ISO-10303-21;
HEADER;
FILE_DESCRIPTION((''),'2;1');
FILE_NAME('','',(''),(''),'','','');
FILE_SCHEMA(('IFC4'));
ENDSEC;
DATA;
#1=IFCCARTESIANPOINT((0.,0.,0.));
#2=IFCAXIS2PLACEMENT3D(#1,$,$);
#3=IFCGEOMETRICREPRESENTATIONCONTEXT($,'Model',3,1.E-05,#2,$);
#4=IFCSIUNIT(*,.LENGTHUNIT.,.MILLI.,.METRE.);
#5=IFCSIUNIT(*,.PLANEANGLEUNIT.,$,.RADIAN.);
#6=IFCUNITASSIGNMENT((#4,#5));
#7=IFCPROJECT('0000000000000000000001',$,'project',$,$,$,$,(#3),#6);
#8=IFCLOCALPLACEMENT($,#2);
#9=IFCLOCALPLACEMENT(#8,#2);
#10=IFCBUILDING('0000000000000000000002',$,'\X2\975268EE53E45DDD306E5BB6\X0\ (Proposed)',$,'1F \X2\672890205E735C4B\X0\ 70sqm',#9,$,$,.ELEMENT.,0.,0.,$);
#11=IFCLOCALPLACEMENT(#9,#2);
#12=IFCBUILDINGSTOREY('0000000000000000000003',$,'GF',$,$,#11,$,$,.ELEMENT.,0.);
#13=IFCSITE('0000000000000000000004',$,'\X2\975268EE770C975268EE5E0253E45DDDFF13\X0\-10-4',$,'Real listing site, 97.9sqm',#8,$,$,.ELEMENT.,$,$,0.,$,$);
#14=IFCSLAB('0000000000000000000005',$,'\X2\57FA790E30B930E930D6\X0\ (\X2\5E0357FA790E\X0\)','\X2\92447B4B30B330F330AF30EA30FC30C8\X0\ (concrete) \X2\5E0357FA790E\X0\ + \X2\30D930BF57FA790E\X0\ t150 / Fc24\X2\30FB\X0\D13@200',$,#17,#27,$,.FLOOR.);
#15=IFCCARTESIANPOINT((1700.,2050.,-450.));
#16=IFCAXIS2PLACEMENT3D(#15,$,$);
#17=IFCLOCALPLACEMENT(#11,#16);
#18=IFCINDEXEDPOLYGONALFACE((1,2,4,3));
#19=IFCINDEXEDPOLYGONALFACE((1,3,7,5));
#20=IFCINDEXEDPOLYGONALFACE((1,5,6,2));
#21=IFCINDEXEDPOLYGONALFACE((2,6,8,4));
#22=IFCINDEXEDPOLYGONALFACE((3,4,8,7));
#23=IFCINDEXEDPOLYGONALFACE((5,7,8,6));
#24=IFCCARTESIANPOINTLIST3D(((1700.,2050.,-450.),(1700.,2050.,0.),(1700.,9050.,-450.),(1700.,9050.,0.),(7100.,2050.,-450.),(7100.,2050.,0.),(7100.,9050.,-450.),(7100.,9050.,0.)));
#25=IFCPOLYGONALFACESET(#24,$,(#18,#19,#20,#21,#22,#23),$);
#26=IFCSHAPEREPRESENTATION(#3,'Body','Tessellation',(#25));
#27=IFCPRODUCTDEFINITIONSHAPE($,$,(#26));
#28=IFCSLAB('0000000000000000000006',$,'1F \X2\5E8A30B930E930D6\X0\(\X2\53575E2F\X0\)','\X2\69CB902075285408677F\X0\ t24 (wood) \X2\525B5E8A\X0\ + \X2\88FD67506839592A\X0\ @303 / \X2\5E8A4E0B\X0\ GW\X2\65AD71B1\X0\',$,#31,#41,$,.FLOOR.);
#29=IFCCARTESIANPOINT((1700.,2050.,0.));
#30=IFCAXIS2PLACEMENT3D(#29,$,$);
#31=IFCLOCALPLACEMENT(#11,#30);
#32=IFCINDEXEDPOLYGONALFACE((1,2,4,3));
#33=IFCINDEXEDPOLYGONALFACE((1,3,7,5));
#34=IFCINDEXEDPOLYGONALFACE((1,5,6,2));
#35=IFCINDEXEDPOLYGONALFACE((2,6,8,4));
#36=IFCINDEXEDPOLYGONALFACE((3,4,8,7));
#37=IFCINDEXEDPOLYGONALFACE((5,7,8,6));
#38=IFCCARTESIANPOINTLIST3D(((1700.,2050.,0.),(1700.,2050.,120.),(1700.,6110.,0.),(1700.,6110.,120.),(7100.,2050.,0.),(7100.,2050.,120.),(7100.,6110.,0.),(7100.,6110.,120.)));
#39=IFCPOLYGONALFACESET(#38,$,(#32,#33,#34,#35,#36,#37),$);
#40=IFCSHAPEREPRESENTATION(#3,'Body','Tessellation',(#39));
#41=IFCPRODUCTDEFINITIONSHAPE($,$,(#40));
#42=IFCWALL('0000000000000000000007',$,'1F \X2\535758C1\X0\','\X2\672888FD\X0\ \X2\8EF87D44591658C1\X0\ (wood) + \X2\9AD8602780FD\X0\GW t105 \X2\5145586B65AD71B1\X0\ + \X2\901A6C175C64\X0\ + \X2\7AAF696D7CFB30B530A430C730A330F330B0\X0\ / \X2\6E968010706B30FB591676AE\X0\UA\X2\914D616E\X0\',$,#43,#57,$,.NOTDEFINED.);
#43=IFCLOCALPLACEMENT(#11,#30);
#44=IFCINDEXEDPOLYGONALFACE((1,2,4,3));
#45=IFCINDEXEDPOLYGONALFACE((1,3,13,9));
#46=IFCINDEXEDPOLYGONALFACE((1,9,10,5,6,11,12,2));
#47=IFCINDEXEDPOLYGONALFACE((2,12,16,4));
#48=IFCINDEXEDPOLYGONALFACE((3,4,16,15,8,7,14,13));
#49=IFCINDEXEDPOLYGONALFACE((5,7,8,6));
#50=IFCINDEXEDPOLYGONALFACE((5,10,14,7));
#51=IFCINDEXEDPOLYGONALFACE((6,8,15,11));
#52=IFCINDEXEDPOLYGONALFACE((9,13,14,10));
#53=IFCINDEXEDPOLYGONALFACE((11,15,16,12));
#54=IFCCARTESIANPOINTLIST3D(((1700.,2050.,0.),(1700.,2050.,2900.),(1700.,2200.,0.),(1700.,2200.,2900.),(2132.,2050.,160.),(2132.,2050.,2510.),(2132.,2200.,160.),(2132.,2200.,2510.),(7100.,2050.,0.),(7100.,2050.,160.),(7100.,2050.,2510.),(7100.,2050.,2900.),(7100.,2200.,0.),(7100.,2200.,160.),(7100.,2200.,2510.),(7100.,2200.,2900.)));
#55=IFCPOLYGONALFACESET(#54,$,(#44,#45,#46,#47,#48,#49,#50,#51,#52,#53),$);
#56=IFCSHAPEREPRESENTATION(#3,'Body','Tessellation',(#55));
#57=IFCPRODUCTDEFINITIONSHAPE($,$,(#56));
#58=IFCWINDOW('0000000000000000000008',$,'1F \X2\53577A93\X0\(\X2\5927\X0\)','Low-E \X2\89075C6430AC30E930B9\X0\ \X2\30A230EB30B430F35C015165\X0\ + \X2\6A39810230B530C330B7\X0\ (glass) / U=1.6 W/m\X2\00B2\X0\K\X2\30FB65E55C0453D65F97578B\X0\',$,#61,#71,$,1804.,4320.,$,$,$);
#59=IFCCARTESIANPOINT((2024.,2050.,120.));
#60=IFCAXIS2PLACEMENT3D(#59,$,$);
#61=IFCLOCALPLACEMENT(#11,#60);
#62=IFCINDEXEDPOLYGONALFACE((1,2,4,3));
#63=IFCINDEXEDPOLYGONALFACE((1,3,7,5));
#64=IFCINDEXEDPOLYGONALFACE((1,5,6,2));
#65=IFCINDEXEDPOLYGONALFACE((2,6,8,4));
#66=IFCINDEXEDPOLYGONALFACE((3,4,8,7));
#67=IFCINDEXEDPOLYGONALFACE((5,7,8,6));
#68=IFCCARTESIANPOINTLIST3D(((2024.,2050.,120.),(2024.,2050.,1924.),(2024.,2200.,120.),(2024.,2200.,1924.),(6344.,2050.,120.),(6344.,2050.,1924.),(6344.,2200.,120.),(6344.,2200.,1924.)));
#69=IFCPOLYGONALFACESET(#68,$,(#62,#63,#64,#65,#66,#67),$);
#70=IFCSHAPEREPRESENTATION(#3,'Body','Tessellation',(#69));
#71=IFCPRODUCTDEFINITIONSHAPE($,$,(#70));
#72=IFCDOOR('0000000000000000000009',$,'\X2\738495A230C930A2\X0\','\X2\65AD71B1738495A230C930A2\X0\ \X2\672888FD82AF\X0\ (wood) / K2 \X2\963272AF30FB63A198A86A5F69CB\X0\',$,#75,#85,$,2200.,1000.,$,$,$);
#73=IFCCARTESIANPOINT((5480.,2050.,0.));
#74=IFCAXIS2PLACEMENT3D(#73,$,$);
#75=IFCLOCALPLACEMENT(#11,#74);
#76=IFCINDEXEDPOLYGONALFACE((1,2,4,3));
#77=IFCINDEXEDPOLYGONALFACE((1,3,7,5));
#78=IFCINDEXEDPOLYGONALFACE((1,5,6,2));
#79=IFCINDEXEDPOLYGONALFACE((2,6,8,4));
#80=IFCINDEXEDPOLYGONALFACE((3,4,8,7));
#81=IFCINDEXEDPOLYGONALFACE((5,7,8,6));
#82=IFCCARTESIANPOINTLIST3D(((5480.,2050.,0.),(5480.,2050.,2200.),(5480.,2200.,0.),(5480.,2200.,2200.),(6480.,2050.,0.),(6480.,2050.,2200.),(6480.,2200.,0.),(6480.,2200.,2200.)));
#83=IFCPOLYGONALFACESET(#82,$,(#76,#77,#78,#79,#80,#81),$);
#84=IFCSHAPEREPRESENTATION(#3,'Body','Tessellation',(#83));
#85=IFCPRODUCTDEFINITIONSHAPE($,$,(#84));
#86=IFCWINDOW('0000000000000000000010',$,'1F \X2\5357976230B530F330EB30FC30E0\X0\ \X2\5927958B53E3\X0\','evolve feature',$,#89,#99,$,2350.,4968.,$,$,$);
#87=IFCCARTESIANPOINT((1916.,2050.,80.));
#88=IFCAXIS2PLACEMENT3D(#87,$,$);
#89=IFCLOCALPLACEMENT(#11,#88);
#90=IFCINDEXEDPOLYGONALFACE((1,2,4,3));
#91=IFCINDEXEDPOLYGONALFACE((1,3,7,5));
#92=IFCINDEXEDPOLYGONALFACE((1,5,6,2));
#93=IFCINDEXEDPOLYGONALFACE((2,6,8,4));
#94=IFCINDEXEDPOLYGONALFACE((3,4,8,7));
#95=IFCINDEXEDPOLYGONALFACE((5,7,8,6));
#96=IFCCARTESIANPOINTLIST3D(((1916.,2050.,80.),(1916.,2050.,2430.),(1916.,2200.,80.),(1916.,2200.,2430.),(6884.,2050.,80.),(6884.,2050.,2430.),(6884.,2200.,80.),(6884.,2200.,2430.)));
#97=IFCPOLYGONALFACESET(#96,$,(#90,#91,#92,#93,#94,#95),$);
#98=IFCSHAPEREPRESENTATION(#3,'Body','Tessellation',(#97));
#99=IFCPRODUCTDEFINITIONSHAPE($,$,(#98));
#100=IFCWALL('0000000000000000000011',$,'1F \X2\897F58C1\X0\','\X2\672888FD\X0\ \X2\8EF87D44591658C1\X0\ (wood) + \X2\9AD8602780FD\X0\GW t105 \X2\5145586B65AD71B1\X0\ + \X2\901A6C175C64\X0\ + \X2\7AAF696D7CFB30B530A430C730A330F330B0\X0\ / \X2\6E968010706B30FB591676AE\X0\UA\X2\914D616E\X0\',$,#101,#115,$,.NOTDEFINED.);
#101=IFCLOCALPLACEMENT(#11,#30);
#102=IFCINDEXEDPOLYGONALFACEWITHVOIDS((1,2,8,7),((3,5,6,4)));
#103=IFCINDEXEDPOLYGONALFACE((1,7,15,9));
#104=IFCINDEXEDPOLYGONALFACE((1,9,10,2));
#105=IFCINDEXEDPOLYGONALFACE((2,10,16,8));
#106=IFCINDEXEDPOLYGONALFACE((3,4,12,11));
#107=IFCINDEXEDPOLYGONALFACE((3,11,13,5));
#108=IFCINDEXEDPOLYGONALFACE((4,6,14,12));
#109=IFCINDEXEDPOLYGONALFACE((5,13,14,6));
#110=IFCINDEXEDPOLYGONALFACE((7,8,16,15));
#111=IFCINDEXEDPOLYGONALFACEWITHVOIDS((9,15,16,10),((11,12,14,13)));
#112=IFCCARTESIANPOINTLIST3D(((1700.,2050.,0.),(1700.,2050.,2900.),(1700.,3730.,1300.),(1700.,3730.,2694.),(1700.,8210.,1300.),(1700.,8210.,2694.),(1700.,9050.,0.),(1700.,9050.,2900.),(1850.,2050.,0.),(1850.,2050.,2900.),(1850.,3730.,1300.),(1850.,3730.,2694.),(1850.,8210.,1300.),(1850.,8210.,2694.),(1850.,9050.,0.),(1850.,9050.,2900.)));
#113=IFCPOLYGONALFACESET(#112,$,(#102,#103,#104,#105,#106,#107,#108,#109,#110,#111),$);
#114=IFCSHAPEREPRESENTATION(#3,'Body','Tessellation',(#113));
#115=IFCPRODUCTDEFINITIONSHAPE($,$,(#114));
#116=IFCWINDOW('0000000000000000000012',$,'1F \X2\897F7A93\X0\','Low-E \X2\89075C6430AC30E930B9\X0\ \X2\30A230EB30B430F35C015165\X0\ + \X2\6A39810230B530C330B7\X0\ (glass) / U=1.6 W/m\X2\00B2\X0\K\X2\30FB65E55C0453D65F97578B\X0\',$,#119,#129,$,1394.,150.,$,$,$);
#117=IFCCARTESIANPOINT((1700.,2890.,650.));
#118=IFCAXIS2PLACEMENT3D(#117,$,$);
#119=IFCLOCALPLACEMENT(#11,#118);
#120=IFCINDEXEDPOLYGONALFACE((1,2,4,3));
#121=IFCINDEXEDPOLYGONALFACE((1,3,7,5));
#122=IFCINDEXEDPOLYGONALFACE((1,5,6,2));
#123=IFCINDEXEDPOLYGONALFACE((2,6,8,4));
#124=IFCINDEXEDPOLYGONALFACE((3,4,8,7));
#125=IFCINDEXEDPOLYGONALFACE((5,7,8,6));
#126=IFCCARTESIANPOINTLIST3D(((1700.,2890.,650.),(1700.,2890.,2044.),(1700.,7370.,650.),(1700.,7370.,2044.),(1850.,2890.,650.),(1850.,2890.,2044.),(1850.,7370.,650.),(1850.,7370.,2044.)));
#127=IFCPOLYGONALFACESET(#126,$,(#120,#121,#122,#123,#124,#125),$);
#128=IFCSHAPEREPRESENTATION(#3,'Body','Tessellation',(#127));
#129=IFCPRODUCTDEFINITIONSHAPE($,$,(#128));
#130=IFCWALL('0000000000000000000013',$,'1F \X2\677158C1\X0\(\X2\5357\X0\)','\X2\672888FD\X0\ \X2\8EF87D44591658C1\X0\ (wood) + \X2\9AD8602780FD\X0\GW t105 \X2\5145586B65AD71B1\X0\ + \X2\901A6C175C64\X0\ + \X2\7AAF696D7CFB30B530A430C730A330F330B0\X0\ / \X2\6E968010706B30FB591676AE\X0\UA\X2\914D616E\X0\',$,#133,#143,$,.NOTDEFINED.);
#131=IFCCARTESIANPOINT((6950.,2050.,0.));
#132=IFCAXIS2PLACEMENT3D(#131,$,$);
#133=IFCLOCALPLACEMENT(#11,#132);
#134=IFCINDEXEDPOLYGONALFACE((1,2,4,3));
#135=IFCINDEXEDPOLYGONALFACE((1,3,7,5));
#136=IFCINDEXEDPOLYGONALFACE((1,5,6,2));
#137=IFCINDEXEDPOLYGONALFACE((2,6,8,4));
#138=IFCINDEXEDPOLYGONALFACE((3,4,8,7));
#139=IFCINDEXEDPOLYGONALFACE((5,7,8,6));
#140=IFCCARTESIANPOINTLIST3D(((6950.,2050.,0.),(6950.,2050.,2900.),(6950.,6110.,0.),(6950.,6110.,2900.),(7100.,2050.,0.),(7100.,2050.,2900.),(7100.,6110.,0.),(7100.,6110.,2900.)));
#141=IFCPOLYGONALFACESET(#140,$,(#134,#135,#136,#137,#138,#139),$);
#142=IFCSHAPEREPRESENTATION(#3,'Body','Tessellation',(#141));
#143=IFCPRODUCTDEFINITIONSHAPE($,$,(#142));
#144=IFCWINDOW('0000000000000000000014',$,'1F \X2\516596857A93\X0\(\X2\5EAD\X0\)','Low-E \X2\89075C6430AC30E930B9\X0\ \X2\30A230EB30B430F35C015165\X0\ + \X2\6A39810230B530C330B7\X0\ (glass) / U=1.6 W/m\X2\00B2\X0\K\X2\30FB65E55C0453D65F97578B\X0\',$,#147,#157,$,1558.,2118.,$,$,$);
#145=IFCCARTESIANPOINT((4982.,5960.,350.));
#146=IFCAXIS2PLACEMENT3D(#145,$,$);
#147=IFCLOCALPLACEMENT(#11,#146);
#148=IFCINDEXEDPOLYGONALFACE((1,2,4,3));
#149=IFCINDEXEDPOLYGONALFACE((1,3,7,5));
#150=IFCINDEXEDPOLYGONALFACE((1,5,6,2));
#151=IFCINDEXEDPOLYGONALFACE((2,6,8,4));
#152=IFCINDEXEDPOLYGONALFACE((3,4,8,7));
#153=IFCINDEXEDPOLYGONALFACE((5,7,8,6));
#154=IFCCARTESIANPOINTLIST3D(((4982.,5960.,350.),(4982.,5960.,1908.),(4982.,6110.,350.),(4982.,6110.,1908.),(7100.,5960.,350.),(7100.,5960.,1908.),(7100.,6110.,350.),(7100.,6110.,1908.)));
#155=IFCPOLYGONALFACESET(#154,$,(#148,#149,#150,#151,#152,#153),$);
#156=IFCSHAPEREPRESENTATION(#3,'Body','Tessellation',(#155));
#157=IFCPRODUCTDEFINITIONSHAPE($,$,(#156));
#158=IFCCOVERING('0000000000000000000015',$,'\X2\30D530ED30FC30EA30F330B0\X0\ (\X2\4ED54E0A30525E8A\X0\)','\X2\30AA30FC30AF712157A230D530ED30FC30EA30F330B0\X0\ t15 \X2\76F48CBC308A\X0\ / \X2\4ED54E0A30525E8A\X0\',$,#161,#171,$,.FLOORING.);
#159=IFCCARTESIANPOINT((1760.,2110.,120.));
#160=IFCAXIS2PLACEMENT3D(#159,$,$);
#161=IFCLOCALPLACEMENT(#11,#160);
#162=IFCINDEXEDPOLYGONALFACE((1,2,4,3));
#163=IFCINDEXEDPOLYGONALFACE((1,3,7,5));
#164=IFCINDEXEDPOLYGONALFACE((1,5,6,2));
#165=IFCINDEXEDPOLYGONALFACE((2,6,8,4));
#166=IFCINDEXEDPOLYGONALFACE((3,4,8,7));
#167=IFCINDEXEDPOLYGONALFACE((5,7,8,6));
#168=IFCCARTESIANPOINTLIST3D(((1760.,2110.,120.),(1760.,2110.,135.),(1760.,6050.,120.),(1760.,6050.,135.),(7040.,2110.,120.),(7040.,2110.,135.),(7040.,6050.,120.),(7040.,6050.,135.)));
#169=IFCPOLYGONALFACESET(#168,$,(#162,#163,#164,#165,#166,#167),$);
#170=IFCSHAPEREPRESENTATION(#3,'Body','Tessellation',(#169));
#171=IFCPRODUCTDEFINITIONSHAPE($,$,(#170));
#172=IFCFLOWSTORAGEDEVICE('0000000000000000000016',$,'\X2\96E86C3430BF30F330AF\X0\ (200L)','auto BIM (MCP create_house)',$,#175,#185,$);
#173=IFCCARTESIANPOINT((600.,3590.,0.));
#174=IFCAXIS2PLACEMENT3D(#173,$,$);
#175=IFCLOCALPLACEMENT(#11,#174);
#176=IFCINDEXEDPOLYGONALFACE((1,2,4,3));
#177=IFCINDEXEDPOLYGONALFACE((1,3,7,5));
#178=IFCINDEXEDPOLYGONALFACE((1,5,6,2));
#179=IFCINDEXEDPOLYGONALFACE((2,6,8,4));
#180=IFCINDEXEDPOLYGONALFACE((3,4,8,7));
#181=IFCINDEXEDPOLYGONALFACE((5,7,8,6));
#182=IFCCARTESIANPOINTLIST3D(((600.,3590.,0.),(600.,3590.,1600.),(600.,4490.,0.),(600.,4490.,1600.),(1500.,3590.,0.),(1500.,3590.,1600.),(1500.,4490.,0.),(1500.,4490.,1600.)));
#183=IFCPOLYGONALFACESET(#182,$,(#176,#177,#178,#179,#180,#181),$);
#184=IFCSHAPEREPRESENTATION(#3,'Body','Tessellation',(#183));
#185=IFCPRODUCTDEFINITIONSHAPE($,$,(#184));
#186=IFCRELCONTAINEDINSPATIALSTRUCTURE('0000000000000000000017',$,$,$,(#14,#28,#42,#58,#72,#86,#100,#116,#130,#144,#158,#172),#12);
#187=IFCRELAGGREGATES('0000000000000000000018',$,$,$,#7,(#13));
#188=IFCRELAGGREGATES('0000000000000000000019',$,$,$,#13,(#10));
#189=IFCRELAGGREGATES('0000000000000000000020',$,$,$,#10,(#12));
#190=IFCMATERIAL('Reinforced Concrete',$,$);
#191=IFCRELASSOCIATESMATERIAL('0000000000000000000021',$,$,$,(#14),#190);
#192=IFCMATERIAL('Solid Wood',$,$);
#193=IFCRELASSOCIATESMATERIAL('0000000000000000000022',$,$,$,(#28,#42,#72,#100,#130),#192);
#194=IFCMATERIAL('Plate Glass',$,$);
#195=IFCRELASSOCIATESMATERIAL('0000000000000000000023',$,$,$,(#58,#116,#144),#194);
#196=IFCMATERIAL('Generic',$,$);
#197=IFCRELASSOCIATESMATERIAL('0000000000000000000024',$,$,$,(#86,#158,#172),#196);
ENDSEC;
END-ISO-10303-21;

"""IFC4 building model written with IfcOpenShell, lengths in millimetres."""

from ifc_helpers import new_model, si_unit, frame, frame_2d, origin, place, context, project, spatial, rectangle, extrude, material, element, fill, save


model = new_model("IFC4")

# Units and contexts
model_context = context("Model", 3, precision=1e-05, world=origin())
ifc_project = project(units=[si_unit("LENGTHUNIT", "METRE", prefix="MILLI"), si_unit("PLANEANGLEUNIT", "RADIAN")], contexts=[model_context])

# Site, building, storey
site_placement = place(None, origin())
site = spatial("IfcSite", under=ifc_project, at=site_placement, Name="青森県青森市古川３-10-4", ObjectType="Real listing site, 97.9sqm", CompositionType="ELEMENT", RefElevation=0.0)
building_placement = place(site_placement, origin())
building = spatial("IfcBuilding", under=site, at=building_placement, Name="青森古川の家 (Proposed)", ObjectType="1F 木造平屋 70sqm", CompositionType="ELEMENT", ElevationOfRefHeight=0.0, ElevationOfTerrain=0.0)
storey_placement = place(building_placement, origin())
storey = spatial("IfcBuildingStorey", under=building, at=storey_placement, Name="GF", CompositionType="ELEMENT", Elevation=0.0)

# Slabs
ifc_material_1 = material(Name="Reinforced Concrete")
slab_1_placement = place(storey_placement, frame((1700.0, 2050.0, -450.0)))
element("IfcSlab", 1, at=slab_1_placement, inside=storey, material=ifc_material_1, Name="基礎スラブ (布基礎)", Description="鉄筋コンクリート (concrete) 布基礎 + ベタ基礎 t150 / Fc24・D13@200", PredefinedType="FLOOR", context=model_context, shape_type="SweptSolid", body=[
    extrude(rectangle(XDim=5400.0, YDim=7000.0, at=frame_2d((2700.0, 3500.0))), frame((1700.0, 2050.0, -450.0)), (0.0, 0.0, 1.0), 450.0),
])
ifc_material_2 = material(Name="Solid Wood")
slab_2_placement = place(storey_placement, frame((1700.0, 2050.0, 0.0)))
element("IfcSlab", 2, at=slab_2_placement, inside=storey, material=ifc_material_2, Name="1F 床スラブ(南帯)", Description="構造用合板 t24 (wood) 剛床 + 製材根太 @303 / 床下 GW断熱", PredefinedType="FLOOR", context=model_context, shape_type="SweptSolid", body=[
    extrude(rectangle(XDim=5400.0, YDim=4060.0, at=frame_2d((2700.0, 2030.0))), frame((1700.0, 2050.0, 0.0)), (0.0, 0.0, 1.0), 120.0),
])

# Wall, openings, windows, door
wall_1_placement = place(storey_placement, frame((1700.0, 2050.0, 0.0)))
wall_1 = element("IfcWall", 3, at=wall_1_placement, inside=storey, material=ifc_material_2, Name="1F 南壁", Description="木製 軸組外壁 (wood) + 高性能GW t105 充填断熱 + 通気層 + 窯業系サイディング / 準耐火・外皮UA配慮", PredefinedType="NOTDEFINED", context=model_context, shape_type="SweptSolid", body=[
    extrude(rectangle(XDim=5400.0, YDim=150.0, at=frame_2d((2700.0, 75.0))), frame((1700.0, 2050.0, 0.0)), (0.0, 0.0, 1.0), 2900.0),
])
opening_1_placement = place(storey_placement, frame((2024.0, 2050.0, 120.0)))
opening_1 = element("IfcOpeningElement", 4, at=opening_1_placement, cuts=wall_1, PredefinedType="NOTDEFINED", context=model_context, shape_type="SweptSolid", body=[
    extrude(rectangle(XDim=4320.0, YDim=150.0, at=frame_2d((2160.0, 75.0))), frame((2024.0, 2050.0, 120.0)), (0.0, 0.0, 1.0), 1804.0),
])
opening_2_placement = place(storey_placement, frame((5480.0, 2050.0, 0.0)))
opening_2 = element("IfcOpeningElement", 5, at=opening_2_placement, cuts=wall_1, PredefinedType="NOTDEFINED", context=model_context, shape_type="SweptSolid", body=[
    extrude(rectangle(XDim=1000.0, YDim=150.0, at=frame_2d((500.0, 75.0))), frame((5480.0, 2050.0, 0.0)), (0.0, 0.0, 1.0), 2200.0),
])
opening_3_placement = place(storey_placement, frame((1916.0, 2050.0, 80.0)))
opening_3 = element("IfcOpeningElement", 6, at=opening_3_placement, cuts=wall_1, PredefinedType="NOTDEFINED", context=model_context, shape_type="SweptSolid", body=[
    extrude(rectangle(XDim=4968.0, YDim=150.0, at=frame_2d((2484.0, 75.0))), frame((1916.0, 2050.0, 80.0)), (0.0, 0.0, 1.0), 2350.0),
])
ifc_material_3 = material(Name="Plate Glass")
window_1_placement = place(storey_placement, frame((2024.0, 2050.0, 120.0)))
window_1 = element("IfcWindow", 7, at=window_1_placement, inside=storey, material=ifc_material_3, Name="1F 南窓(大)", Description="Low-E 複層ガラス アルゴン封入 + 樹脂サッシ (glass) / U=1.6 W/m²K・日射取得型", OverallHeight=1804.0, OverallWidth=4320.0, context=model_context, shape_type="SweptSolid", body=[
    extrude(rectangle(XDim=4320.0, YDim=150.0, at=frame_2d((2160.0, 75.0))), frame((2024.0, 2050.0, 120.0)), (0.0, 0.0, 1.0), 1804.0),
])
fill(opening_1, window_1)
door_1_placement = place(storey_placement, frame((5480.0, 2050.0, 0.0)))
door_1 = element("IfcDoor", 8, at=door_1_placement, inside=storey, material=ifc_material_2, Name="玄関ドア", Description="断熱玄関ドア 木製芯 (wood) / K2 防犯・採風機構", OverallHeight=2200.0, OverallWidth=1000.0, context=model_context, shape_type="SweptSolid", body=[
    extrude(rectangle(XDim=1000.0, YDim=150.0, at=frame_2d((500.0, 75.0))), frame((5480.0, 2050.0, 0.0)), (0.0, 0.0, 1.0), 2200.0),
])
fill(opening_2, door_1)
ifc_material_4 = material(Name="Generic")
window_2_placement = place(storey_placement, frame((1916.0, 2050.0, 80.0)))
window_2 = element("IfcWindow", 9, at=window_2_placement, inside=storey, material=ifc_material_4, Name="1F 南面サンルーム 大開口", Description="evolve feature", OverallHeight=2350.0, OverallWidth=4968.0, context=model_context, shape_type="SweptSolid", body=[
    extrude(rectangle(XDim=4968.0, YDim=150.0, at=frame_2d((2484.0, 75.0))), frame((1916.0, 2050.0, 80.0)), (0.0, 0.0, 1.0), 2350.0),
])
fill(opening_3, window_2)

# Walls, openings, windows
wall_2_placement = place(storey_placement, frame((1700.0, 2050.0, 0.0)))
wall_2 = element("IfcWall", 10, at=wall_2_placement, inside=storey, material=ifc_material_2, Name="1F 西壁", Description="木製 軸組外壁 (wood) + 高性能GW t105 充填断熱 + 通気層 + 窯業系サイディング / 準耐火・外皮UA配慮", PredefinedType="NOTDEFINED", context=model_context, shape_type="SweptSolid", body=[
    extrude(rectangle(XDim=150.0, YDim=7000.0, at=frame_2d((75.0, 3500.0))), frame((1700.0, 2050.0, 0.0)), (0.0, 0.0, 1.0), 2900.0),
])
opening_4_placement = place(storey_placement, frame((1700.0, 2890.0, 650.0)))
opening_4 = element("IfcOpeningElement", 11, at=opening_4_placement, cuts=wall_2, PredefinedType="NOTDEFINED", context=model_context, shape_type="SweptSolid", body=[
    extrude(rectangle(XDim=150.0, YDim=4480.0, at=frame_2d((75.0, 2240.0))), frame((1700.0, 2890.0, 650.0)), (0.0, 0.0, 1.0), 1394.0),
])
window_3_placement = place(storey_placement, frame((1700.0, 2890.0, 650.0)))
window_3 = element("IfcWindow", 12, at=window_3_placement, inside=storey, material=ifc_material_3, Name="1F 西窓", Description="Low-E 複層ガラス アルゴン封入 + 樹脂サッシ (glass) / U=1.6 W/m²K・日射取得型", OverallHeight=1394.0, OverallWidth=150.0, context=model_context, shape_type="SweptSolid", body=[
    extrude(rectangle(XDim=150.0, YDim=4480.0, at=frame_2d((75.0, 2240.0))), frame((1700.0, 2890.0, 650.0)), (0.0, 0.0, 1.0), 1394.0),
])
fill(opening_4, window_3)
wall_3_placement = place(storey_placement, frame((6950.0, 2050.0, 0.0)))
wall_3 = element("IfcWall", 13, at=wall_3_placement, inside=storey, material=ifc_material_2, Name="1F 東壁(南)", Description="木製 軸組外壁 (wood) + 高性能GW t105 充填断熱 + 通気層 + 窯業系サイディング / 準耐火・外皮UA配慮", PredefinedType="NOTDEFINED", context=model_context, shape_type="SweptSolid", body=[
    extrude(rectangle(XDim=150.0, YDim=4060.0, at=frame_2d((75.0, 2030.0))), frame((6950.0, 2050.0, 0.0)), (0.0, 0.0, 1.0), 2900.0),
])
opening_5_placement = place(storey_placement, frame((4982.0, 5960.0, 350.0)))
opening_5 = element("IfcOpeningElement", 14, at=opening_5_placement, cuts=wall_3, PredefinedType="NOTDEFINED", context=model_context, shape_type="SweptSolid", body=[
    extrude(rectangle(XDim=2118.0, YDim=150.0, at=frame_2d((1059.0, 75.0))), frame((4982.0, 5960.0, 350.0)), (0.0, 0.0, 1.0), 1558.0),
])
window_4_placement = place(storey_placement, frame((4982.0, 5960.0, 350.0)))
window_4 = element("IfcWindow", 15, at=window_4_placement, inside=storey, material=ifc_material_3, Name="1F 入隅窓(庭)", Description="Low-E 複層ガラス アルゴン封入 + 樹脂サッシ (glass) / U=1.6 W/m²K・日射取得型", OverallHeight=1558.0, OverallWidth=2118.0, context=model_context, shape_type="SweptSolid", body=[
    extrude(rectangle(XDim=2118.0, YDim=150.0, at=frame_2d((1059.0, 75.0))), frame((4982.0, 5960.0, 350.0)), (0.0, 0.0, 1.0), 1558.0),
])
fill(opening_5, window_4)

# Covering
covering_placement = place(storey_placement, frame((1760.0, 2110.0, 120.0)))
element("IfcCovering", 16, at=covering_placement, inside=storey, material=ifc_material_4, Name="フローリング (仕上げ床)", Description="オーク無垢フローリング t15 直貼り / 仕上げ床", PredefinedType="FLOORING", context=model_context, shape_type="SweptSolid", body=[
    extrude(rectangle(XDim=5280.0, YDim=3940.0, at=frame_2d((2640.0, 1970.0))), frame((1760.0, 2110.0, 120.0)), (0.0, 0.0, 1.0), 15.0),
])

# Flow storage device
flow_storage_device_placement = place(storey_placement, frame((600.0, 3590.0, 0.0)))
element("IfcFlowStorageDevice", 17, at=flow_storage_device_placement, inside=storey, material=ifc_material_4, Name="雨水タンク (200L)", Description="auto BIM (MCP create_house)", context=model_context, shape_type="SweptSolid", body=[
    extrude(rectangle(XDim=900.0, YDim=900.0, at=frame_2d((450.0, 450.0))), frame((600.0, 3590.0, 0.0)), (0.0, 0.0, 1.0), 1600.0),
])

save(model, "model.ifc")
